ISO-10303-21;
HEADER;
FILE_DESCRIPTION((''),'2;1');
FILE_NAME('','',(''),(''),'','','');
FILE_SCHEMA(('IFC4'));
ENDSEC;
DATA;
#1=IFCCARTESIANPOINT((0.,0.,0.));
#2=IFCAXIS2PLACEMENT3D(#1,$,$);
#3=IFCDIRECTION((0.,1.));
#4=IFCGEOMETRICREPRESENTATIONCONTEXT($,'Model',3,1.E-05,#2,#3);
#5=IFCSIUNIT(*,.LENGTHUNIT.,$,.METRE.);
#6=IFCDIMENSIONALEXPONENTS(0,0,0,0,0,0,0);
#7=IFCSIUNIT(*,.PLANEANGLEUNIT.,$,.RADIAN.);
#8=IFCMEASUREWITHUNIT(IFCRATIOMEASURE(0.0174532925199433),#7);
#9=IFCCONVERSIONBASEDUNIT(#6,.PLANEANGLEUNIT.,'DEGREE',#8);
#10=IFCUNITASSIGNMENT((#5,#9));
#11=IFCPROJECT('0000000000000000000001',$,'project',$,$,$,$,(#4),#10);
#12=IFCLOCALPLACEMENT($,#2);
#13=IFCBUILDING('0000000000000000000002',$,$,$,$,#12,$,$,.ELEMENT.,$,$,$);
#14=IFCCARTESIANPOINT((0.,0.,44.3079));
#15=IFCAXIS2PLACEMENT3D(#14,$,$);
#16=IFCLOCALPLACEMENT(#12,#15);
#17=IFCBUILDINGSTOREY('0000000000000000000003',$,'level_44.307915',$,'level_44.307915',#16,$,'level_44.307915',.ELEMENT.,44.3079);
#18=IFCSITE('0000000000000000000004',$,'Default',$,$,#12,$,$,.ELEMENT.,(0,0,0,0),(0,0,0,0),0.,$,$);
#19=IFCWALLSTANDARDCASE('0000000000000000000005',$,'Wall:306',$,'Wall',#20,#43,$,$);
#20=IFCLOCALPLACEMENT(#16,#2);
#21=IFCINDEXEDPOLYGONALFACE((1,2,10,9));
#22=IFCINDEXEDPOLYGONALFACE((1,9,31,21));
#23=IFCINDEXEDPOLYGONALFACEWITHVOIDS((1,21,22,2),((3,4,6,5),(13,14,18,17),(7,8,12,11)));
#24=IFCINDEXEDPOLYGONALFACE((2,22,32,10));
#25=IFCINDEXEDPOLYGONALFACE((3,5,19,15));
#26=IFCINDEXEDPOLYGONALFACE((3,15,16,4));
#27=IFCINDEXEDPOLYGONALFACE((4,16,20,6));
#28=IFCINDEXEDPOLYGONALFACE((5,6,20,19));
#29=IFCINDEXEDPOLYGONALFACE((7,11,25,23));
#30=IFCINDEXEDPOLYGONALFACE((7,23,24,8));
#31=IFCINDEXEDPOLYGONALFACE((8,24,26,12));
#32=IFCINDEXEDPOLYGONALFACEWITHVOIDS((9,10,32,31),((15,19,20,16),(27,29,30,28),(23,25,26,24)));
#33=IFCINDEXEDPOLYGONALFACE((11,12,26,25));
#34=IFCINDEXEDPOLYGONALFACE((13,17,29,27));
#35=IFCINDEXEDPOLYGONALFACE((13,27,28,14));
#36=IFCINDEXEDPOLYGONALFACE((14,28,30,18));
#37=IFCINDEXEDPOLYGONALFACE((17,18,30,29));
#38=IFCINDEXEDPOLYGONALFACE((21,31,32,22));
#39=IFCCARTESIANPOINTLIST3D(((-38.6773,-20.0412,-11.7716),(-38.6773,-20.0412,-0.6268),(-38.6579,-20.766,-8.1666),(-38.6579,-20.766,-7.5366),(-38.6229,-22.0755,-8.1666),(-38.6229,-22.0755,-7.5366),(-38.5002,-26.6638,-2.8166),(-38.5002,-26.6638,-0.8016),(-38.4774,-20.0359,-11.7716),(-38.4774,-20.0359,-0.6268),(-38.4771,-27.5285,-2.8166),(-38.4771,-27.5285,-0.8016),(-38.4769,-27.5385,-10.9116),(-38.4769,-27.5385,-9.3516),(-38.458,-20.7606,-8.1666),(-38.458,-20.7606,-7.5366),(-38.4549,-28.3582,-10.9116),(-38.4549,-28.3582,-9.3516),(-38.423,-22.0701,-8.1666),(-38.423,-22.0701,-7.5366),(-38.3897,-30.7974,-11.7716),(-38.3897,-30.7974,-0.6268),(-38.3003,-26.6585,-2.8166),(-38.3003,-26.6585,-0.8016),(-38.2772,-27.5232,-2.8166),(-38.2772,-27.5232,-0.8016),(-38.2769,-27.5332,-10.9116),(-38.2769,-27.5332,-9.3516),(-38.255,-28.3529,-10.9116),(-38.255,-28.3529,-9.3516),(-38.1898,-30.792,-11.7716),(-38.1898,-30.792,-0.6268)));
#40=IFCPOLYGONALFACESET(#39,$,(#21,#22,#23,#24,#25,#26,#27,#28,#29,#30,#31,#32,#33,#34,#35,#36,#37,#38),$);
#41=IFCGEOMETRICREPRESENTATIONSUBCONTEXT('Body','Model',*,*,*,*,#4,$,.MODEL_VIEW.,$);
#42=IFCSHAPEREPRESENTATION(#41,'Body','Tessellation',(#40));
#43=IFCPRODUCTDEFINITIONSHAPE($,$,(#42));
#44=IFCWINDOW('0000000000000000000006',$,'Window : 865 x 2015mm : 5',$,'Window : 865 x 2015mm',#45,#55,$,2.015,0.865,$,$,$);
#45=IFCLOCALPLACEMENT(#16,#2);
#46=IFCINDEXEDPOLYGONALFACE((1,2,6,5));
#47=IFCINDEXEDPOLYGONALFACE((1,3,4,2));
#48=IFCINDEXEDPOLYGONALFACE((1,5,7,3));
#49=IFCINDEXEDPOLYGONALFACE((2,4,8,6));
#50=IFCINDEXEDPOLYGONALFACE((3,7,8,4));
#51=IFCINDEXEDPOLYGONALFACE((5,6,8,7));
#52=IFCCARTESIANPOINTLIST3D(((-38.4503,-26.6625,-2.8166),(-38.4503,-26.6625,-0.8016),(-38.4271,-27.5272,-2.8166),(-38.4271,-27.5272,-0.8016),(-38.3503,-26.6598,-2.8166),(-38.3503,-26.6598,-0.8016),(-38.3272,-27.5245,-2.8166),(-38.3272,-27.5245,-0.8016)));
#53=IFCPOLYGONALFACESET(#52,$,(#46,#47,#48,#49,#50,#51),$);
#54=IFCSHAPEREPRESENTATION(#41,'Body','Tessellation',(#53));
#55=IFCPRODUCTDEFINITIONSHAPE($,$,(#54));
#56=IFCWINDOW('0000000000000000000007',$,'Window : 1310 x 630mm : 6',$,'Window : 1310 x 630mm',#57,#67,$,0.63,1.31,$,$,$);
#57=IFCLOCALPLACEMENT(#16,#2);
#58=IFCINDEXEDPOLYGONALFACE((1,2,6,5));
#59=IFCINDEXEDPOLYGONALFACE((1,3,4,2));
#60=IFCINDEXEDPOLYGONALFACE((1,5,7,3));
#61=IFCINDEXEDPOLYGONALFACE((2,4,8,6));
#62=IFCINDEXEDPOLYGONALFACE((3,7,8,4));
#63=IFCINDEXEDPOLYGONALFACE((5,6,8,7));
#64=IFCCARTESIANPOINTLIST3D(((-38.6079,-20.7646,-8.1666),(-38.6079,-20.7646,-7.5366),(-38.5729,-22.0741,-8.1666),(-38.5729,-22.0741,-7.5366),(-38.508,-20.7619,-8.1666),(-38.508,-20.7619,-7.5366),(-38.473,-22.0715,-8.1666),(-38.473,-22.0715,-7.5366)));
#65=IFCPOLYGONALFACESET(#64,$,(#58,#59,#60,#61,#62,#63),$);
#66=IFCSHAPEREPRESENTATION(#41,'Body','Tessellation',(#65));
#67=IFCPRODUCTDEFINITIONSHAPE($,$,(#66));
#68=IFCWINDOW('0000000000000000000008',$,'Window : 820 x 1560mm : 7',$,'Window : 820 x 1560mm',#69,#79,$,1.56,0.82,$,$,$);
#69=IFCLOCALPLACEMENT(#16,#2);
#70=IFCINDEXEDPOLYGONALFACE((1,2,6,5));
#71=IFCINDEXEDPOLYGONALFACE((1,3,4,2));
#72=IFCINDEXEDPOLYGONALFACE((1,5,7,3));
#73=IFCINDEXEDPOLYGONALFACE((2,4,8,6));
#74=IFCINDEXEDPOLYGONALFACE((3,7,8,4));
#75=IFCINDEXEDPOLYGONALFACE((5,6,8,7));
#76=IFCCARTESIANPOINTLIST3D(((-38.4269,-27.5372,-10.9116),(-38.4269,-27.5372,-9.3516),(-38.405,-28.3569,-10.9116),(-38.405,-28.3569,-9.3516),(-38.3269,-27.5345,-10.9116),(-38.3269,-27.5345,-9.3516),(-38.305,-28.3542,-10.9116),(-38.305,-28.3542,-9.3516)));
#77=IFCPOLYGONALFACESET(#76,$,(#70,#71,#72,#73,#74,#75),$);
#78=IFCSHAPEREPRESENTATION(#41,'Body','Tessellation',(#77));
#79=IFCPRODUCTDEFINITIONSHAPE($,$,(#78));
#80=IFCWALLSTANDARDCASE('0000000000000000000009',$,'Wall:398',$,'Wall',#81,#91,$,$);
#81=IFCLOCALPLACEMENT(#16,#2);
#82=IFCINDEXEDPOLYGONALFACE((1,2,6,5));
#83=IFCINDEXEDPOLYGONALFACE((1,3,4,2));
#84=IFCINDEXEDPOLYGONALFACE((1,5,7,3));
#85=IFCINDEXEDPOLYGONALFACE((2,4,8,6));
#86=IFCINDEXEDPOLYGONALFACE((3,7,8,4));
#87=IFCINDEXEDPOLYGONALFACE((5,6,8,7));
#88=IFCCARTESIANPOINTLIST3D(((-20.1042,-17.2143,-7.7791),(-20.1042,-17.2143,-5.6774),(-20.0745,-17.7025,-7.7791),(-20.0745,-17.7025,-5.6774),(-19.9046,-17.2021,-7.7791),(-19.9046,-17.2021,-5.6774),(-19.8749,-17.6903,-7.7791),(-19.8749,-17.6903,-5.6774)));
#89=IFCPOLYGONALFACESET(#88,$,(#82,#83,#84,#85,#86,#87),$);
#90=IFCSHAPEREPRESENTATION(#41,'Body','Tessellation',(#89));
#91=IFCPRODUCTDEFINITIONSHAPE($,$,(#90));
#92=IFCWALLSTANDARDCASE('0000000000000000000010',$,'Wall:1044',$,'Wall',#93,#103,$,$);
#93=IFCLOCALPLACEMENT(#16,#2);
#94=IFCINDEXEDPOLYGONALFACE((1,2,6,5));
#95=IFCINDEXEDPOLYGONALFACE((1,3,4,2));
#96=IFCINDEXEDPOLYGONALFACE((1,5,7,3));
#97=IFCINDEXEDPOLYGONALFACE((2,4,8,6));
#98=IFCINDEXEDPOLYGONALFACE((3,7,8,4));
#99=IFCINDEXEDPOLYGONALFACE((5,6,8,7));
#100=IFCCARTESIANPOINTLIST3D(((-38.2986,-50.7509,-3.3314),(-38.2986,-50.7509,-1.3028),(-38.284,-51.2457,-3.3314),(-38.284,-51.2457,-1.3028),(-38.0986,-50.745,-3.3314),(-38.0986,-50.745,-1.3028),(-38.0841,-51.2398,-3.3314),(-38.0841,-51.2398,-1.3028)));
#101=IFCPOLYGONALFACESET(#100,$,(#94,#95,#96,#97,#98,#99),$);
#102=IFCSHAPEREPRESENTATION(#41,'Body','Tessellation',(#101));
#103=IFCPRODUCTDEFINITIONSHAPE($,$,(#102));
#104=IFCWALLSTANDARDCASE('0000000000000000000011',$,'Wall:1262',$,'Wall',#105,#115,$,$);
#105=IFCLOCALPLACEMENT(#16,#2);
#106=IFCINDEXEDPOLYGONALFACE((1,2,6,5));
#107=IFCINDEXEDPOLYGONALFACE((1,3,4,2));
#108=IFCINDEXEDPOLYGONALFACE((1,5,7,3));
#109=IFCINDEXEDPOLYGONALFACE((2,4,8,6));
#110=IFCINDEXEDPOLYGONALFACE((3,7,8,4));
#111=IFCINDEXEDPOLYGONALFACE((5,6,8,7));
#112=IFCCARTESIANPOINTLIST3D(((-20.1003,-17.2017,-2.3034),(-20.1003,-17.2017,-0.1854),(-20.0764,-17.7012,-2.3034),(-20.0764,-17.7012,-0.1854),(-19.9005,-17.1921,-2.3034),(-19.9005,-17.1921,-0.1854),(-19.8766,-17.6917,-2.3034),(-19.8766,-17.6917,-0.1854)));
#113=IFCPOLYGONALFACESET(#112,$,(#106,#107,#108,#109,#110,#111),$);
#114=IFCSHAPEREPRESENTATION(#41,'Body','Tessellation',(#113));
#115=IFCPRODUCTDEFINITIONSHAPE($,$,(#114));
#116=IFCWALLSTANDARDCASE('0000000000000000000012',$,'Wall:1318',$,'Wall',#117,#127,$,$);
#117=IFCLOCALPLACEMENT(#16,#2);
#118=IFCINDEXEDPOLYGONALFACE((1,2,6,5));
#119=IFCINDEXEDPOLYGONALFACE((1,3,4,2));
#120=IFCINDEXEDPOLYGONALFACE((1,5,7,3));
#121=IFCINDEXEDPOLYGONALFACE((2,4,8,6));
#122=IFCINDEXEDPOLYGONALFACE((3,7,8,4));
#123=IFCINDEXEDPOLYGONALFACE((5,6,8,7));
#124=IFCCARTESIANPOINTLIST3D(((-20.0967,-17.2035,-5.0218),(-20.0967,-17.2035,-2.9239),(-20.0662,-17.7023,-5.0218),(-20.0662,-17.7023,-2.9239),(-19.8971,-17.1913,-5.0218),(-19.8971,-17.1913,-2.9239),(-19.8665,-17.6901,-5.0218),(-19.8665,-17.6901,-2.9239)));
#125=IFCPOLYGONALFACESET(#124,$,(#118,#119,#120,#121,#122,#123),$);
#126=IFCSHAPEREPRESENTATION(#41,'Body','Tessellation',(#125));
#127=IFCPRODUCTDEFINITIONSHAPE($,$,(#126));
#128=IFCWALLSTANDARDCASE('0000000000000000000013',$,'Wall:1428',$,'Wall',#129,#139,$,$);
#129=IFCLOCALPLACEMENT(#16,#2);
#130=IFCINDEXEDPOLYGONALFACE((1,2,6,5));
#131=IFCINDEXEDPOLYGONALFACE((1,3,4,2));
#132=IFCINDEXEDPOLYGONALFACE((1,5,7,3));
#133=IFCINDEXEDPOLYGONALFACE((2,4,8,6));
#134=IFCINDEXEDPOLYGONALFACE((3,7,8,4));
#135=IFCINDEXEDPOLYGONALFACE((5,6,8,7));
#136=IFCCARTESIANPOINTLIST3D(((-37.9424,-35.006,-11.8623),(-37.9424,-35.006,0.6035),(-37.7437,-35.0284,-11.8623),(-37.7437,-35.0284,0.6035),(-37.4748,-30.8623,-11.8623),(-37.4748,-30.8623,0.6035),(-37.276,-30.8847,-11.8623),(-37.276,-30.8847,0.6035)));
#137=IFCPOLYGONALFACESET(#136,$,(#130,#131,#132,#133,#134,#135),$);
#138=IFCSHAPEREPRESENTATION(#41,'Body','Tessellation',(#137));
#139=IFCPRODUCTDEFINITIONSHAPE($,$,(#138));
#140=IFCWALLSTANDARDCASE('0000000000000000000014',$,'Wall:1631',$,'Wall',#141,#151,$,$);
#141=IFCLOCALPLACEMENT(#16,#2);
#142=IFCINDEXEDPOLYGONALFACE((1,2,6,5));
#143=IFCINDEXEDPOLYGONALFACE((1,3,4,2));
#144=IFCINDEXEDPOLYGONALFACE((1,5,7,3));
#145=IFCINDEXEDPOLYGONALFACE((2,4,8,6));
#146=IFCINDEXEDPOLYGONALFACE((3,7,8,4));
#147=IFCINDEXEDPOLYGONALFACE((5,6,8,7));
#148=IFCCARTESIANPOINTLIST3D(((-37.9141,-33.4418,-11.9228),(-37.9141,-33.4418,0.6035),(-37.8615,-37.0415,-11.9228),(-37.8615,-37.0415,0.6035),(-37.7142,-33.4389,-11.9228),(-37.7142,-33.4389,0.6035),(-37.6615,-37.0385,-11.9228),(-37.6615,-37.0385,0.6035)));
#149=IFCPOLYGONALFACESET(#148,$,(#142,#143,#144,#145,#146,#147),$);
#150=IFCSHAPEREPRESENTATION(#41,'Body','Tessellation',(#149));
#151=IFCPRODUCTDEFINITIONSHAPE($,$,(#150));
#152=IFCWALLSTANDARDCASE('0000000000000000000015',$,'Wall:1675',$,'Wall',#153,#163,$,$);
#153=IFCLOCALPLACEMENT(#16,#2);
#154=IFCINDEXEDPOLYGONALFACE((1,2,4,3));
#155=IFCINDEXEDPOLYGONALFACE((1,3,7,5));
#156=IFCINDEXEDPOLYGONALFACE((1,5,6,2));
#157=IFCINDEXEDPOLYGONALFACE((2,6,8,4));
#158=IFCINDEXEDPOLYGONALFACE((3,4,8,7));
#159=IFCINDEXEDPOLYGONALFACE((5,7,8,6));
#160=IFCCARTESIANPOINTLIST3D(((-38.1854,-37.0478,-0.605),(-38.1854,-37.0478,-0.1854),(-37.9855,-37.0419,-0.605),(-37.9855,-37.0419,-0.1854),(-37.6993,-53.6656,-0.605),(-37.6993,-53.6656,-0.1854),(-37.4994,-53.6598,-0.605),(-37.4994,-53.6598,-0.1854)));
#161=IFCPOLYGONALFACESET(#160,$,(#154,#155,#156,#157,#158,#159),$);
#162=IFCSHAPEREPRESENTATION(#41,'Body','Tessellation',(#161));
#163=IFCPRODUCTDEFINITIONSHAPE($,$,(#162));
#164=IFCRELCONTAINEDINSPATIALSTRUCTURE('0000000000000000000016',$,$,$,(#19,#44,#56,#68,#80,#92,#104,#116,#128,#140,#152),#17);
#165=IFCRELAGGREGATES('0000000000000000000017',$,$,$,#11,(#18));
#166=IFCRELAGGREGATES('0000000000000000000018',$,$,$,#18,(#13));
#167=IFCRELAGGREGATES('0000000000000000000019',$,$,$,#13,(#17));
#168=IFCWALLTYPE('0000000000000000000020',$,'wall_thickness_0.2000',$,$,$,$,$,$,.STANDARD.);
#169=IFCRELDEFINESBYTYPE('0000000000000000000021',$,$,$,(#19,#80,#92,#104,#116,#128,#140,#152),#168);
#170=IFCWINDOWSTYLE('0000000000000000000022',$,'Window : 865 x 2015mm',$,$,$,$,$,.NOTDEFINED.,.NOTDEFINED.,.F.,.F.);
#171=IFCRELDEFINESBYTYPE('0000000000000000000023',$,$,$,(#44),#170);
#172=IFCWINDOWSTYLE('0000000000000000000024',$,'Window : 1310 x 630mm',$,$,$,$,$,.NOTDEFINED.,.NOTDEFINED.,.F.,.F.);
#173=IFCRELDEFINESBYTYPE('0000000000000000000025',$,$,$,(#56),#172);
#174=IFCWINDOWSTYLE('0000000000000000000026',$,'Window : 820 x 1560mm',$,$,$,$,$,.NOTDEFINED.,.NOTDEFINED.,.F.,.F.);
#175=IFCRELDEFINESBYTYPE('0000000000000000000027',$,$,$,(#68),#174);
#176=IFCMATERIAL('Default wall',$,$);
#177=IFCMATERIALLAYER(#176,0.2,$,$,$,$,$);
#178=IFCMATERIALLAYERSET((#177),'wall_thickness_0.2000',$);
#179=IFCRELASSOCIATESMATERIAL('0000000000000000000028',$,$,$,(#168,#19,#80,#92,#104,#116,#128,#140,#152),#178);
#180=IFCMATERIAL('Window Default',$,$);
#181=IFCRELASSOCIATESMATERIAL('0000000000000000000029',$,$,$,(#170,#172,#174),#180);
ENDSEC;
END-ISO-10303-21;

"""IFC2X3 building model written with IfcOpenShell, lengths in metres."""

from ifc_helpers import new_model, entity, si_unit, converted_unit, direction, frame, frame_2d, origin, origin_2d_with_axis, place, context, subcontext, project, spatial, polyline, rectangle, outline, extrude, source, transform, mapped, material, layer, layer_set, layer_usage, type_object, type_shapes, element, fill, save


model = new_model("IFC2X3")

# Units and contexts
model_context = context("Model", 3, precision=1e-05, world=origin(), true_north=direction((0.0, 1.0)))
body_context = subcontext(model_context, "Body", "Model", "MODEL_VIEW")
ifc_project = project(units=[si_unit("LENGTHUNIT", "METRE"), converted_unit("PLANEANGLEUNIT", "DEGREE", entity("IfcRatioMeasure", 0.0174532925199433), si_unit("PLANEANGLEUNIT", "RADIAN"), dimensions=[0, 0, 0, 0, 0, 0, 0])], contexts=[model_context])

# Site, building, storey
placement_1 = place(None, origin())
site = spatial("IfcSite", under=ifc_project, at=placement_1, Name="Default", CompositionType="ELEMENT", RefLatitude=(0, 0, 0, 0), RefLongitude=(0, 0, 0, 0), RefElevation=0.0)
building = spatial("IfcBuilding", under=site, at=placement_1, CompositionType="ELEMENT")
storey_placement = place(placement_1, frame((0.0, 0.0, 44.3079)))
storey = spatial("IfcBuildingStorey", under=building, at=storey_placement, Name="level_44.307915", ObjectType="level_44.307915", LongName="level_44.307915", CompositionType="ELEMENT", Elevation=44.3079)

# Shared definitions
ifc_material_1 = material(Name="Default wall")
ifc_layer = layer(ifc_material_1, 0.2)
ifc_layer_set = layer_set([ifc_layer], Name="wall_thickness_0.2000")
ifc_layer_usage = layer_usage(ifc_layer_set, "AXIS2", "POSITIVE", -0.1)
wall_type = type_object("IfcWallType", Name="wall_thickness_0.2000", PredefinedType="STANDARD", material=ifc_layer_set)
ifc_material_2 = material(Name="Window Default")

# Wall, openings, windows
placement_2 = place(placement_1, frame((0.0, 0.0, 32.5363)))
wall_1_placement = place(placement_2, frame((-38.2898, -30.7947, 0.0), z_axis=(0.0, 0.0, 1.0), x_axis=(-0.026725, 0.999643, 0.0)))
wall_1 = element("IfcWallStandardCase", 1, at=wall_1_placement, inside=storey, type_object=wall_type, material=ifc_layer_usage, Name="Wall:306", ObjectType="Wall", context=body_context, shape_type="SweptSolid", body=[
    extrude(outline(polyline([(10.76, -0.1), (10.76, 0.1), (0.0, 0.1), (0.0, -0.1), (10.76, -0.1)])), origin(), (0.0, 0.0, 1.0), 11.1449),
])
opening_1_placement = place(wall_1_placement, frame((3.27, -0.1, 8.955)))
opening_1 = element("IfcOpeningElement", 2, at=opening_1_placement, cuts=wall_1, ObjectType="Opening", context=body_context, shape_type="SweptSolid", body=[
    extrude(rectangle(XDim=0.865, YDim=2.015, at=frame_2d((1.0075, 0.4325), x_axis=(0.0, 1.0))), frame((0.0, 0.0, 0.0), z_axis=(0.0, 1.0, 0.0), x_axis=(0.0, 0.0, 1.0)), (0.0, 0.0, 1.0), 0.2),
])
opening_2_placement = place(wall_1_placement, frame((8.725, -0.1, 3.605)))
opening_2 = element("IfcOpeningElement", 3, at=opening_2_placement, cuts=wall_1, ObjectType="Opening", context=body_context, shape_type="SweptSolid", body=[
    extrude(rectangle(XDim=1.31, YDim=0.63, at=frame_2d((0.315, 0.655), x_axis=(0.0, 1.0))), frame((0.0, 0.0, 0.0), z_axis=(0.0, 1.0, 0.0), x_axis=(0.0, 0.0, 1.0)), (0.0, 0.0, 1.0), 0.2),
])
opening_3_placement = place(wall_1_placement, frame((2.44, -0.1, 0.86)))
opening_3 = element("IfcOpeningElement", 4, at=opening_3_placement, cuts=wall_1, ObjectType="Opening", context=body_context, shape_type="SweptSolid", body=[
    extrude(rectangle(XDim=0.82, YDim=1.56, at=frame_2d((0.78, 0.41), x_axis=(0.0, 1.0))), frame((0.0, 0.0, 0.0), z_axis=(0.0, 1.0, 0.0), x_axis=(0.0, 0.0, 1.0)), (0.0, 0.0, 1.0), 0.2),
])
window_style_1 = type_object("IfcWindowStyle", Name="Window : 865 x 2015mm", ConstructionType="NOTDEFINED", OperationType="NOTDEFINED", ParameterTakesPrecedence=False, Sizeable=False, material=ifc_material_2)
shared_shape_1 = source(origin(), body_context, "Body", "SweptSolid", [
    extrude(rectangle(XDim=0.1, YDim=0.865, at=origin_2d_with_axis()), frame((0.4325, 0.1, 0.0), z_axis=(0.0, 0.0, 1.0), x_axis=(0.0, 1.0, 0.0)), (0.0, 0.0, 1.0), 2.015),
])
type_shapes(window_style_1, [shared_shape_1])
window_1_placement = place(opening_1_placement, origin())
window_1 = element("IfcWindow", 5, at=window_1_placement, inside=storey, type_object=window_style_1, Name="Window : 865 x 2015mm : 5", ObjectType="Window : 865 x 2015mm", OverallHeight=2.015, OverallWidth=0.865, context=body_context, shape_type="MappedRepresentation", body=[
    mapped(shared_shape_1, transform((0.0, 0.0, 0.0), scale=1.0)),
])
fill(opening_1, window_1)
window_style_2 = type_object("IfcWindowStyle", Name="Window : 1310 x 630mm", ConstructionType="NOTDEFINED", OperationType="NOTDEFINED", ParameterTakesPrecedence=False, Sizeable=False, material=ifc_material_2)
shared_shape_2 = source(origin(), body_context, "Body", "SweptSolid", [
    extrude(rectangle(XDim=0.1, YDim=1.31, at=origin_2d_with_axis()), frame((0.655, 0.1, 0.0), z_axis=(0.0, 0.0, 1.0), x_axis=(0.0, 1.0, 0.0)), (0.0, 0.0, 1.0), 0.63),
])
type_shapes(window_style_2, [shared_shape_2])
window_2_placement = place(opening_2_placement, origin())
window_2 = element("IfcWindow", 6, at=window_2_placement, inside=storey, type_object=window_style_2, Name="Window : 1310 x 630mm : 6", ObjectType="Window : 1310 x 630mm", OverallHeight=0.63, OverallWidth=1.31, context=body_context, shape_type="MappedRepresentation", body=[
    mapped(shared_shape_2, transform((0.0, 0.0, 0.0), scale=1.0)),
])
fill(opening_2, window_2)
window_style_3 = type_object("IfcWindowStyle", Name="Window : 820 x 1560mm", ConstructionType="NOTDEFINED", OperationType="NOTDEFINED", ParameterTakesPrecedence=False, Sizeable=False, material=ifc_material_2)
shared_shape_3 = source(origin(), body_context, "Body", "SweptSolid", [
    extrude(rectangle(XDim=0.1, YDim=0.82, at=origin_2d_with_axis()), frame((0.41, 0.1, 0.0), z_axis=(0.0, 0.0, 1.0), x_axis=(0.0, 1.0, 0.0)), (0.0, 0.0, 1.0), 1.56),
])
type_shapes(window_style_3, [shared_shape_3])
window_3_placement = place(opening_3_placement, origin())
window_3 = element("IfcWindow", 7, at=window_3_placement, inside=storey, type_object=window_style_3, Name="Window : 820 x 1560mm : 7", ObjectType="Window : 820 x 1560mm", OverallHeight=1.56, OverallWidth=0.82, context=body_context, shape_type="MappedRepresentation", body=[
    mapped(shared_shape_3, transform((0.0, 0.0, 0.0), scale=1.0)),
])
fill(opening_3, window_3)

# Walls
placement_3 = place(placement_1, frame((0.0, 0.0, 36.5288)))
wall_2_placement = place(placement_3, frame((-19.9747, -17.6964, 0.0), z_axis=(0.0, 0.0, 1.0), x_axis=(-0.060736, 0.998154, 0.0)))
element("IfcWallStandardCase", 8, at=wall_2_placement, inside=storey, type_object=wall_type, material=ifc_layer_usage, Name="Wall:398", ObjectType="Wall", context=body_context, shape_type="SweptSolid", body=[
    extrude(outline(polyline([(0.4891, -0.1), (0.4891, 0.1), (0.0, 0.1), (0.0, -0.1), (0.4891, -0.1)])), origin(), (0.0, 0.0, 1.0), 2.1017),
])
placement_4 = place(placement_1, frame((0.0, 0.0, 40.9765)))
wall_3_placement = place(placement_4, frame((-38.1986, -50.748, 0.0), z_axis=(0.0, 0.0, 1.0), x_axis=(0.0294, -0.999568, 0.0)))
element("IfcWallStandardCase", 9, at=wall_3_placement, inside=storey, type_object=wall_type, material=ifc_layer_usage, Name="Wall:1044", ObjectType="Wall", context=body_context, shape_type="SweptSolid", body=[
    extrude(outline(polyline([(0.495, -0.1), (0.495, 0.1), (0.0, 0.1), (0.0, -0.1), (0.495, -0.1)])), origin(), (0.0, 0.0, 1.0), 2.0286),
])
placement_5 = place(placement_1, frame((0.0, 0.0, 42.0045)))
wall_4_placement = place(placement_5, frame((-20.0004, -17.1969, 0.0), z_axis=(0.0, 0.0, 1.0), x_axis=(0.047739, -0.99886, 0.0)))
element("IfcWallStandardCase", 10, at=wall_4_placement, inside=storey, type_object=wall_type, material=ifc_layer_usage, Name="Wall:1262", ObjectType="Wall", context=body_context, shape_type="SweptSolid", body=[
    extrude(outline(polyline([(0.5001, -0.1), (0.5001, 0.1), (0.0, 0.1), (0.0, -0.1), (0.5001, -0.1)])), origin(), (0.0, 0.0, 1.0), 2.118),
])
placement_6 = place(placement_1, frame((0.0, 0.0, 39.2861)))
wall_5_placement = place(placement_6, frame((-19.9969, -17.1974, 0.0), z_axis=(0.0, 0.0, 1.0), x_axis=(0.061093, -0.998132, 0.0)))
element("IfcWallStandardCase", 11, at=wall_5_placement, inside=storey, type_object=wall_type, material=ifc_layer_usage, Name="Wall:1318", ObjectType="Wall", context=body_context, shape_type="SweptSolid", body=[
    extrude(outline(polyline([(0.4997, -0.1), (0.4997, 0.1), (0.0, 0.1), (0.0, -0.1), (0.4997, -0.1)])), origin(), (0.0, 0.0, 1.0), 2.0979),
])
placement_7 = place(placement_1, frame((0.0, 0.0, 32.4456)))
wall_6_placement = place(placement_7, frame((-37.3754, -30.8735, 0.0), z_axis=(0.0, 0.0, 1.0), x_axis=(-0.112145, -0.993692, 0.0)))
element("IfcWallStandardCase", 12, at=wall_6_placement, inside=storey, type_object=wall_type, material=ifc_layer_usage, Name="Wall:1428", ObjectType="Wall", context=body_context, shape_type="SweptSolid", body=[
    extrude(outline(polyline([(4.17, -0.1), (4.17, 0.1), (0.0, 0.1), (0.0, -0.1), (4.17, -0.1)])), origin(), (0.0, 0.0, 1.0), 12.4658),
])
placement_8 = place(placement_1, frame((0.0, 0.0, 32.3851)))
wall_7_placement = place(placement_8, frame((-37.8142, -33.4404, 0.0), z_axis=(0.0, 0.0, 1.0), x_axis=(0.01463, -0.999893, 0.0)))
element("IfcWallStandardCase", 13, at=wall_7_placement, inside=storey, type_object=wall_type, material=ifc_layer_usage, Name="Wall:1631", ObjectType="Wall", context=body_context, shape_type="SweptSolid", body=[
    extrude(outline(polyline([(3.6, -0.1), (3.6, 0.1), (0.0, 0.1), (0.0, -0.1), (3.6, -0.1)])), origin(), (0.0, 0.0, 1.0), 12.5262),
])
placement_9 = place(placement_1, frame((0.0, 0.0, 43.7029)))
wall_8_placement = place(placement_9, frame((-38.0854, -37.0448, 0.0), z_axis=(0.0, 0.0, 1.0), x_axis=(0.029241, -0.999572, 0.0)))
element("IfcWallStandardCase", 14, at=wall_8_placement, inside=storey, type_object=wall_type, material=ifc_layer_usage, Name="Wall:1675", ObjectType="Wall", context=body_context, shape_type="SweptSolid", body=[
    extrude(outline(polyline([(16.625, -0.1), (16.625, 0.1), (0.0, 0.1), (0.0, -0.1), (16.625, -0.1)])), origin(), (0.0, 0.0, 1.0), 0.4196),
])

save(model, "model.ifc")
